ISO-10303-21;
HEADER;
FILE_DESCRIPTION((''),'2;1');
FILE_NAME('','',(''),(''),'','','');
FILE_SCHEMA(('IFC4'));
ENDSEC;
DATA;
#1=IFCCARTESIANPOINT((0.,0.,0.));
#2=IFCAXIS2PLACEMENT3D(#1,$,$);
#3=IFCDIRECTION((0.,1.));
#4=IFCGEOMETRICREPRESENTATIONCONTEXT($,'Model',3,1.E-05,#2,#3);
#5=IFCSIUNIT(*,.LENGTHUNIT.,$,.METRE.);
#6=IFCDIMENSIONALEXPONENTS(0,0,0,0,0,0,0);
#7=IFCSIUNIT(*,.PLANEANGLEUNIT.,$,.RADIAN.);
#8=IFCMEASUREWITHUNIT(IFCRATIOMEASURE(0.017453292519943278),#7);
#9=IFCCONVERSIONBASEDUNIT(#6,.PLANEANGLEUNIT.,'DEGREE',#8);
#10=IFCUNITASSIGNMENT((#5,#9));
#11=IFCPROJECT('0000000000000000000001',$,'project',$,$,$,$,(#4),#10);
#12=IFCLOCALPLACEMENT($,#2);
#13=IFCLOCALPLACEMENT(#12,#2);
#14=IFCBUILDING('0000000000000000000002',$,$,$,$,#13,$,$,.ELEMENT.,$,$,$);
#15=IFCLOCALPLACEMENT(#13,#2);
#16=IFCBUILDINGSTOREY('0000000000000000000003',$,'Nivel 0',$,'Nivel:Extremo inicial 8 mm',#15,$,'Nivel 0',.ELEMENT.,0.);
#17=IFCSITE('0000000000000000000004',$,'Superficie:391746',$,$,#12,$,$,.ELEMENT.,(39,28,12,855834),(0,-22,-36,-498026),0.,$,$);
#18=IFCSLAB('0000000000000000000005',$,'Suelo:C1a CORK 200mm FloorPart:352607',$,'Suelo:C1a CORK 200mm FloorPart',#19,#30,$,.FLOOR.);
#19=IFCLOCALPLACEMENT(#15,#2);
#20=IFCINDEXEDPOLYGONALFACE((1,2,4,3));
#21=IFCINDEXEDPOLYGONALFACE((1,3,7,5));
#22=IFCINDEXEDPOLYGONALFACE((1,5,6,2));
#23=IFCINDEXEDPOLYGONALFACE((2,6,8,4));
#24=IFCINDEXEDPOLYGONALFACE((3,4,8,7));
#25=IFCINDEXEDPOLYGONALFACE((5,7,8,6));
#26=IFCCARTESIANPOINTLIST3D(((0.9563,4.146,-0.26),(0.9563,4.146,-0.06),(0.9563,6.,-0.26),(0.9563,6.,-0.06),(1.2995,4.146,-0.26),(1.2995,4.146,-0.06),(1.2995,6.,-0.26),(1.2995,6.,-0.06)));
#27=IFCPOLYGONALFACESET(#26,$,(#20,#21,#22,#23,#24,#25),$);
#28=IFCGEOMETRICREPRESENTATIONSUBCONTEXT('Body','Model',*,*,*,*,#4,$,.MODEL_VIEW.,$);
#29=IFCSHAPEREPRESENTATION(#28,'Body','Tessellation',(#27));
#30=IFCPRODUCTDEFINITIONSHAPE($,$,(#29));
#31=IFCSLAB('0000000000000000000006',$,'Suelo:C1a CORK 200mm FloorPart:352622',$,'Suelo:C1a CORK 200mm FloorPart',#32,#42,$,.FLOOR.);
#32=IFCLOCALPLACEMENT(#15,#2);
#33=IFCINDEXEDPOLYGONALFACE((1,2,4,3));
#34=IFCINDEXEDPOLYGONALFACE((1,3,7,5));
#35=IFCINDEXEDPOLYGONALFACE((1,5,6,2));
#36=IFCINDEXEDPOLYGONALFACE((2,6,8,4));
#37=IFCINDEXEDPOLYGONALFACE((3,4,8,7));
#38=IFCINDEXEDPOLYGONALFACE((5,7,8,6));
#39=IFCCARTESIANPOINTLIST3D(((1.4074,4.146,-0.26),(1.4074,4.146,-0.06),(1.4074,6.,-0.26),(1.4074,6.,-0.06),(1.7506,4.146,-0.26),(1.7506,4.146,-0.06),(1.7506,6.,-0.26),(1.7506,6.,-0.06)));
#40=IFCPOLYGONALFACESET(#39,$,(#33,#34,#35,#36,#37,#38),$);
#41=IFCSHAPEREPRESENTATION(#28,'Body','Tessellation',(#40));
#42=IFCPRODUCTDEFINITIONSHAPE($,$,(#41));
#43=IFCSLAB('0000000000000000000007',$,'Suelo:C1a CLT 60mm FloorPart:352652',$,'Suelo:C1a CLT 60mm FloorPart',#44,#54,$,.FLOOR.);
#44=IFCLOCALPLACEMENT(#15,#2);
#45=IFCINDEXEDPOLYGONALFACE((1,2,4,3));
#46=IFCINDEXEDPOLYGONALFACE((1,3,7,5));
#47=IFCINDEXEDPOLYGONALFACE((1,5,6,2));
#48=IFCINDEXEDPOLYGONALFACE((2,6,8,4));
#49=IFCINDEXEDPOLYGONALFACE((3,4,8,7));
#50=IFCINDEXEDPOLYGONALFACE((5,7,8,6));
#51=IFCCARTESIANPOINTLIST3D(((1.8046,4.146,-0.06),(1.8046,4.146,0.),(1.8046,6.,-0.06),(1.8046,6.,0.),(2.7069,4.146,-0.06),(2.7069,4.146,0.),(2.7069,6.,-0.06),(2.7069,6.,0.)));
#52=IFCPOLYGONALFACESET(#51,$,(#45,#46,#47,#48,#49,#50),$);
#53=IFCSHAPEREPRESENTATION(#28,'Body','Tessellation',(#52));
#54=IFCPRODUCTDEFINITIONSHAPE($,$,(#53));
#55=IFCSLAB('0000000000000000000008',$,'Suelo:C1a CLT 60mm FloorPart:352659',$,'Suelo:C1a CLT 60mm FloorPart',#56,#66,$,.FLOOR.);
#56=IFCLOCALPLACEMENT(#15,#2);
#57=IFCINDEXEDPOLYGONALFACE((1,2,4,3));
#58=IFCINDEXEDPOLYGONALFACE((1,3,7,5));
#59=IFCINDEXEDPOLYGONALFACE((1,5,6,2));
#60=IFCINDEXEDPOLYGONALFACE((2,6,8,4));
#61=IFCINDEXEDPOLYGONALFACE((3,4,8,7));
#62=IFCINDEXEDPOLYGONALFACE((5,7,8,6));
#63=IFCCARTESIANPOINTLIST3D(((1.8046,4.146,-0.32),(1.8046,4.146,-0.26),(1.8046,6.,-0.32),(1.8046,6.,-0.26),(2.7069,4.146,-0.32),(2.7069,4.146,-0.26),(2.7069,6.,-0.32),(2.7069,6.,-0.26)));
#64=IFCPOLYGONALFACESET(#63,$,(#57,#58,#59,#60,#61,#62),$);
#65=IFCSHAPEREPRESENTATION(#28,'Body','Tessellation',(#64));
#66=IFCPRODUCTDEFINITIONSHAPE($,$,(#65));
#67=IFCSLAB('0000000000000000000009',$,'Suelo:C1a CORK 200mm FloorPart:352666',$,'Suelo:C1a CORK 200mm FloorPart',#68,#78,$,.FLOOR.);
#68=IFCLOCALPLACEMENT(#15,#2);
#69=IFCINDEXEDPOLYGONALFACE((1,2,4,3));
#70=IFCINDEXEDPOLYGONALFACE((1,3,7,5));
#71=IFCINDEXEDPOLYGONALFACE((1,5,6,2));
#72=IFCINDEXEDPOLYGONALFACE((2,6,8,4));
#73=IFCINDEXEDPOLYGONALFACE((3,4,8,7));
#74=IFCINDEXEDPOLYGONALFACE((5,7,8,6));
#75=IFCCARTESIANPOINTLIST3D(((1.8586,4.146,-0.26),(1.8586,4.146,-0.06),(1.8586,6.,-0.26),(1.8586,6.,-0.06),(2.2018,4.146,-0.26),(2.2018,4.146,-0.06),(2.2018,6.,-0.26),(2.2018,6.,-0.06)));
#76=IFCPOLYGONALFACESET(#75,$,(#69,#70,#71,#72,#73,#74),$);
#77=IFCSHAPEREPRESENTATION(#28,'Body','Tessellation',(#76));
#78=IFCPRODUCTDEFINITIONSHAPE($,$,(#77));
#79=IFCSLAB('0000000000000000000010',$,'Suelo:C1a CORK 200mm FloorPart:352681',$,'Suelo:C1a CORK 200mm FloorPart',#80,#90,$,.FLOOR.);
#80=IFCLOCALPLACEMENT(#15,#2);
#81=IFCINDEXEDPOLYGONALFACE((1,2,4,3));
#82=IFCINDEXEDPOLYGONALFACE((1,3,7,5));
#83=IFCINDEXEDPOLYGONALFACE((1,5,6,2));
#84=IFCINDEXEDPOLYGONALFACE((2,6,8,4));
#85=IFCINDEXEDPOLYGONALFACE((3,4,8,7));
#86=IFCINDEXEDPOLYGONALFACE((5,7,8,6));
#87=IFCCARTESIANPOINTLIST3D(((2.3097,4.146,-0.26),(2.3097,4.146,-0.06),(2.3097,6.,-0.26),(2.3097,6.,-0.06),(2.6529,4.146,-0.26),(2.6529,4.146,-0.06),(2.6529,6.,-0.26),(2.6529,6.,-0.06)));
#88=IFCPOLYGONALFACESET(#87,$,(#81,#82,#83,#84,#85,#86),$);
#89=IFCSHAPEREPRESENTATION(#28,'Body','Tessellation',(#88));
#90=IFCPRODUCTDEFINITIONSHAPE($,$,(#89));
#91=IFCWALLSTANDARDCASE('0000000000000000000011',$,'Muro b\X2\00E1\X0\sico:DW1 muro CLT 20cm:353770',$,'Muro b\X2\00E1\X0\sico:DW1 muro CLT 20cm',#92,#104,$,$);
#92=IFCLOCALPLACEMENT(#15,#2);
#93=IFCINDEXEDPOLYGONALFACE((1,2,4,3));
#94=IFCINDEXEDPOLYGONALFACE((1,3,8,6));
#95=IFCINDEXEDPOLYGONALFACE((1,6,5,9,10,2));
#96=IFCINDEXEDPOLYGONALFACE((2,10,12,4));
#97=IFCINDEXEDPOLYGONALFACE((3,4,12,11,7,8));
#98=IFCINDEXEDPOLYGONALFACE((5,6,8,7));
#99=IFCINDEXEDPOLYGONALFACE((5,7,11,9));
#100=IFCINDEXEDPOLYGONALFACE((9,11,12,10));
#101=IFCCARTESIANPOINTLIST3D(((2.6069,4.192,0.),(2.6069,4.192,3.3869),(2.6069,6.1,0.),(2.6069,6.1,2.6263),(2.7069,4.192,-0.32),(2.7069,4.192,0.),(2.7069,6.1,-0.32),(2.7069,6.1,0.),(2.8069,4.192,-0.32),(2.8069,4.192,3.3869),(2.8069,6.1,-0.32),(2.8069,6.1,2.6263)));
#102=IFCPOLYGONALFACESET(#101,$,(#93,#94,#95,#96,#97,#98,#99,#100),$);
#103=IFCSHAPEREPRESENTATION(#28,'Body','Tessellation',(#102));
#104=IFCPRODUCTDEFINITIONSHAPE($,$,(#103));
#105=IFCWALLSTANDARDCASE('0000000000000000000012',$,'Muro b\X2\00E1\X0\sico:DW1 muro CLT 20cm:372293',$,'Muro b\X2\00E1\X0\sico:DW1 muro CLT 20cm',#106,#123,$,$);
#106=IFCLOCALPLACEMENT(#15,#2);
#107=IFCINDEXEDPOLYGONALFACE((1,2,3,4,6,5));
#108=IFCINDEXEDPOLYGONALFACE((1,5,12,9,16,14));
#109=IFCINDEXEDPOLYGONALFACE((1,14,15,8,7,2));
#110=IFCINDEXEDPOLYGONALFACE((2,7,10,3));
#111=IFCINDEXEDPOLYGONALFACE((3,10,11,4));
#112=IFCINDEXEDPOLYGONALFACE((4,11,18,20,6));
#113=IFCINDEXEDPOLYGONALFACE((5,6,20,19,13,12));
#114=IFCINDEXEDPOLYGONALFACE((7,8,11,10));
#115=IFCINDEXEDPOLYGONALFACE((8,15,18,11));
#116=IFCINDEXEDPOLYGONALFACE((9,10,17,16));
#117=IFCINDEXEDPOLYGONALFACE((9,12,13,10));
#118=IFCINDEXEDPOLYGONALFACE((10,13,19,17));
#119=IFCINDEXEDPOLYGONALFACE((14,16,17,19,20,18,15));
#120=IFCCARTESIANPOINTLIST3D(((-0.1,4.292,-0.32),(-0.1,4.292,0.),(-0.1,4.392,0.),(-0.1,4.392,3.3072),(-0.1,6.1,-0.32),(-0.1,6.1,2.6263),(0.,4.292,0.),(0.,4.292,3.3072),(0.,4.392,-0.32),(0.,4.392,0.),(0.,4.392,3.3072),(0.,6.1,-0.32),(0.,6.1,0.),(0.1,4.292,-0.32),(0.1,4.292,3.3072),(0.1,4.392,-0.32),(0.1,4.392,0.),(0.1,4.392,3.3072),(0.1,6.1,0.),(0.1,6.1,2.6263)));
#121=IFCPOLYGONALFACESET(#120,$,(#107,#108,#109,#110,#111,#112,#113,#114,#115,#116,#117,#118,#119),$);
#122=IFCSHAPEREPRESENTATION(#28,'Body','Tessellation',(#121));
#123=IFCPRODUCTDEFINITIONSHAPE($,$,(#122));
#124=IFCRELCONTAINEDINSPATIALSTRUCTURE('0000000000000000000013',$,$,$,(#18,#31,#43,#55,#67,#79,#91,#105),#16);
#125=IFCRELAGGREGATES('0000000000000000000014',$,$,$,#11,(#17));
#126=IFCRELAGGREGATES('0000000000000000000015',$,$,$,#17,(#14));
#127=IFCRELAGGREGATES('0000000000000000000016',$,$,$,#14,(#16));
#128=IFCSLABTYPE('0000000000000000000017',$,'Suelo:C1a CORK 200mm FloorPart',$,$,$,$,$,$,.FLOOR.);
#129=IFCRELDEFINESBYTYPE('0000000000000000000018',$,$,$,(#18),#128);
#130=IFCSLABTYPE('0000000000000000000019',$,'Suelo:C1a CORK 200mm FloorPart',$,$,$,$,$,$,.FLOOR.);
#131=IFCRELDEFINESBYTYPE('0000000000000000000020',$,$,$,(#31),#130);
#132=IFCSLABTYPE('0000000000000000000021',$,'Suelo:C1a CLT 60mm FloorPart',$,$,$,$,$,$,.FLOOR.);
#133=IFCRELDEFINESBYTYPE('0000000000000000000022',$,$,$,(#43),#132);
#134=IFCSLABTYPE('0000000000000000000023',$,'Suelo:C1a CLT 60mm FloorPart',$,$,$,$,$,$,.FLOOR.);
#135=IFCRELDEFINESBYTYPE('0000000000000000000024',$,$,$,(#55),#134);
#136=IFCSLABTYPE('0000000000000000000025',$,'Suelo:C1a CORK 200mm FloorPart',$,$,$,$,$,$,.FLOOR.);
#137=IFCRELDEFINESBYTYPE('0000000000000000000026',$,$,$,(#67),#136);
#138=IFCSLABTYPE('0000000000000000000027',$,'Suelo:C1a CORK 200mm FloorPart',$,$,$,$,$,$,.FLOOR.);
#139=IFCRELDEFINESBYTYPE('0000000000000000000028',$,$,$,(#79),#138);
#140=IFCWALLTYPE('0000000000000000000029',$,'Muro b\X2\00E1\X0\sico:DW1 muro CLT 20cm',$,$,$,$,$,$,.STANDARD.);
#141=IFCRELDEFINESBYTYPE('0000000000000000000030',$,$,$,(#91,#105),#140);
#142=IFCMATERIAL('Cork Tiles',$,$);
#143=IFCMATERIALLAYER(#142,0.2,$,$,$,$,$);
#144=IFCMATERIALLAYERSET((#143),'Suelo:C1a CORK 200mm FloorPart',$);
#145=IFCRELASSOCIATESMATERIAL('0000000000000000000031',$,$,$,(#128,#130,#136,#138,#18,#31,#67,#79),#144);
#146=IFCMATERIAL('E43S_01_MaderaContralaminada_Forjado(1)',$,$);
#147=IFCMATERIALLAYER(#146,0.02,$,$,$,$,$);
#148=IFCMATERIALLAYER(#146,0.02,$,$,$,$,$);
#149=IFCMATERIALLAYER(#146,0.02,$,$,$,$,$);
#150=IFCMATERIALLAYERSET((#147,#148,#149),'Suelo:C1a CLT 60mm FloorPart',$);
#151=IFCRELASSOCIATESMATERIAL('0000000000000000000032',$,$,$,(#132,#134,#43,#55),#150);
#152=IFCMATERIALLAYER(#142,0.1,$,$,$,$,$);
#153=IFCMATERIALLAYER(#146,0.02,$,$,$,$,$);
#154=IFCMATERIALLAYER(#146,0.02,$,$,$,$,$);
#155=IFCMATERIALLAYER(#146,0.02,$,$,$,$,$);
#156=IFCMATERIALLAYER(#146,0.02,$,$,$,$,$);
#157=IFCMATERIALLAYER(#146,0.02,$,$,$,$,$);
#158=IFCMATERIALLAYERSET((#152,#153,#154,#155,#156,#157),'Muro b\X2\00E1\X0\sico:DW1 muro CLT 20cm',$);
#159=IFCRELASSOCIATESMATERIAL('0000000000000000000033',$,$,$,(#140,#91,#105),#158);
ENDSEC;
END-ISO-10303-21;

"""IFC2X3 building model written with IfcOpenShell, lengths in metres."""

from ifc_helpers import new_model, entity, si_unit, converted_unit, direction, frame, frame_2d, origin, origin_2d_with_axis, place, context, subcontext, project, spatial, polyline, rectangle, extrude, clip, bounded_halfspace, material, layer, layer_set, layer_usage, type_object, element, save


model = new_model("IFC2X3")

# Units and contexts
model_context = context("Model", 3, precision=1e-05, world=origin(), true_north=direction((0.0, 1.0)))
body_context = subcontext(model_context, "Body", "Model", "MODEL_VIEW")
ifc_project = project(units=[si_unit("LENGTHUNIT", "METRE"), converted_unit("PLANEANGLEUNIT", "DEGREE", entity("IfcRatioMeasure", 0.017453292519943278), si_unit("PLANEANGLEUNIT", "RADIAN"), dimensions=[0, 0, 0, 0, 0, 0, 0])], contexts=[model_context])

# Site, building, storey
site_placement = place(None, origin())
site = spatial("IfcSite", under=ifc_project, at=site_placement, Name="Superficie:391746", CompositionType="ELEMENT", RefLatitude=(39, 28, 12, 855834), RefLongitude=(0, -22, -36, -498026), RefElevation=0.0)
building_placement = place(site_placement, origin())
building = spatial("IfcBuilding", under=site, at=building_placement, CompositionType="ELEMENT")
storey_placement = place(building_placement, origin())
storey = spatial("IfcBuildingStorey", under=building, at=storey_placement, Name="Nivel 0", ObjectType="Nivel:Extremo inicial 8 mm", LongName="Nivel 0", CompositionType="ELEMENT", Elevation=0.0)

# Shared definitions
ifc_material_1 = material(Name="E43S_01_MaderaContralaminada_Forjado(1)")

# Slabs
ifc_layer_1 = layer(ifc_material_1, 0.02)
ifc_layer_2 = layer(ifc_material_1, 0.02)
ifc_layer_3 = layer(ifc_material_1, 0.02)
ifc_layer_set_1 = layer_set([ifc_layer_1, ifc_layer_2, ifc_layer_3], Name="Suelo:C1a CLT 60mm FloorPart")
ifc_material_2 = material(Name="Cork Tiles")
ifc_layer_4 = layer(ifc_material_2, 0.2)
ifc_layer_set_2 = layer_set([ifc_layer_4], Name="Suelo:C1a CORK 200mm FloorPart")
ifc_layer_usage_1 = layer_usage(ifc_layer_set_2, "AXIS3", "POSITIVE", 0.0)
slab_type_1 = type_object("IfcSlabType", Name="Suelo:C1a CORK 200mm FloorPart", PredefinedType="FLOOR", material=ifc_layer_set_2)
slab_1_placement = place(storey_placement, origin())
element("IfcSlab", 1, at=slab_1_placement, inside=storey, type_object=slab_type_1, material=ifc_layer_usage_1, Name="Suelo:C1a CORK 200mm FloorPart:352607", ObjectType="Suelo:C1a CORK 200mm FloorPart", PredefinedType="FLOOR", context=body_context, shape_type="SweptSolid", body=[
    extrude(rectangle(XDim=1.854, YDim=0.3432, at=frame_2d((0.0, 0.0), x_axis=(1.0, 0.0))), frame((1.1279, 5.073, -0.06), z_axis=(0.0, 0.0, -1.0), x_axis=(0.0, 1.0, 0.0)), (0.0, 0.0, 1.0), 0.2),
])
ifc_layer_usage_2 = layer_usage(ifc_layer_set_2, "AXIS3", "POSITIVE", 0.0)
slab_type_2 = type_object("IfcSlabType", Name="Suelo:C1a CORK 200mm FloorPart", PredefinedType="FLOOR", material=ifc_layer_set_2)
slab_2_placement = place(storey_placement, origin())
element("IfcSlab", 2, at=slab_2_placement, inside=storey, type_object=slab_type_2, material=ifc_layer_usage_2, Name="Suelo:C1a CORK 200mm FloorPart:352622", ObjectType="Suelo:C1a CORK 200mm FloorPart", PredefinedType="FLOOR", context=body_context, shape_type="SweptSolid", body=[
    extrude(rectangle(XDim=1.854, YDim=0.3432, at=frame_2d((0.0, 0.0), x_axis=(1.0, 0.0))), frame((1.579, 5.073, -0.06), z_axis=(0.0, 0.0, -1.0), x_axis=(0.0, 1.0, 0.0)), (0.0, 0.0, 1.0), 0.2),
])
ifc_layer_usage_3 = layer_usage(ifc_layer_set_1, "AXIS3", "POSITIVE", 0.0)
slab_type_3 = type_object("IfcSlabType", Name="Suelo:C1a CLT 60mm FloorPart", PredefinedType="FLOOR", material=ifc_layer_set_1)
slab_3_placement = place(storey_placement, origin())
element("IfcSlab", 3, at=slab_3_placement, inside=storey, type_object=slab_type_3, material=ifc_layer_usage_3, Name="Suelo:C1a CLT 60mm FloorPart:352652", ObjectType="Suelo:C1a CLT 60mm FloorPart", PredefinedType="FLOOR", context=body_context, shape_type="SweptSolid", body=[
    extrude(rectangle(XDim=1.854, YDim=0.9023, at=frame_2d((0.0, 0.0), x_axis=(1.0, 0.0))), frame((2.2558, 5.073, 0.0), z_axis=(0.0, 0.0, -1.0), x_axis=(0.0, 1.0, 0.0)), (0.0, 0.0, 1.0), 0.06),
])
ifc_layer_usage_4 = layer_usage(ifc_layer_set_1, "AXIS3", "POSITIVE", 0.0)
slab_type_4 = type_object("IfcSlabType", Name="Suelo:C1a CLT 60mm FloorPart", PredefinedType="FLOOR", material=ifc_layer_set_1)
slab_4_placement = place(storey_placement, origin())
element("IfcSlab", 4, at=slab_4_placement, inside=storey, type_object=slab_type_4, material=ifc_layer_usage_4, Name="Suelo:C1a CLT 60mm FloorPart:352659", ObjectType="Suelo:C1a CLT 60mm FloorPart", PredefinedType="FLOOR", context=body_context, shape_type="SweptSolid", body=[
    extrude(rectangle(XDim=1.854, YDim=0.9023, at=frame_2d((0.0, 0.0), x_axis=(1.0, 0.0))), frame((2.2558, 5.073, -0.26), z_axis=(0.0, 0.0, -1.0), x_axis=(0.0, 1.0, 0.0)), (0.0, 0.0, 1.0), 0.06),
])
ifc_layer_usage_5 = layer_usage(ifc_layer_set_2, "AXIS3", "POSITIVE", 0.0)
slab_type_5 = type_object("IfcSlabType", Name="Suelo:C1a CORK 200mm FloorPart", PredefinedType="FLOOR", material=ifc_layer_set_2)
slab_5_placement = place(storey_placement, origin())
element("IfcSlab", 5, at=slab_5_placement, inside=storey, type_object=slab_type_5, material=ifc_layer_usage_5, Name="Suelo:C1a CORK 200mm FloorPart:352666", ObjectType="Suelo:C1a CORK 200mm FloorPart", PredefinedType="FLOOR", context=body_context, shape_type="SweptSolid", body=[
    extrude(rectangle(XDim=1.854, YDim=0.3432, at=frame_2d((0.0, 0.0), x_axis=(1.0, 0.0))), frame((2.0302, 5.073, -0.06), z_axis=(0.0, 0.0, -1.0), x_axis=(0.0, 1.0, 0.0)), (0.0, 0.0, 1.0), 0.2),
])
ifc_layer_usage_6 = layer_usage(ifc_layer_set_2, "AXIS3", "POSITIVE", 0.0)
slab_type_6 = type_object("IfcSlabType", Name="Suelo:C1a CORK 200mm FloorPart", PredefinedType="FLOOR", material=ifc_layer_set_2)
slab_6_placement = place(storey_placement, origin())
element("IfcSlab", 6, at=slab_6_placement, inside=storey, type_object=slab_type_6, material=ifc_layer_usage_6, Name="Suelo:C1a CORK 200mm FloorPart:352681", ObjectType="Suelo:C1a CORK 200mm FloorPart", PredefinedType="FLOOR", context=body_context, shape_type="SweptSolid", body=[
    extrude(rectangle(XDim=1.854, YDim=0.3432, at=origin_2d_with_axis()), frame((2.4813, 5.073, -0.06), z_axis=(0.0, 0.0, -1.0), x_axis=(0.0, 1.0, 0.0)), (0.0, 0.0, 1.0), 0.2),
])

# Walls
ifc_layer_5 = layer(ifc_material_2, 0.1)
ifc_layer_6 = layer(ifc_material_1, 0.02)
ifc_layer_7 = layer(ifc_material_1, 0.02)
ifc_layer_8 = layer(ifc_material_1, 0.02)
ifc_layer_9 = layer(ifc_material_1, 0.02)
ifc_layer_10 = layer(ifc_material_1, 0.02)
ifc_layer_set_3 = layer_set([ifc_layer_5, ifc_layer_6, ifc_layer_7, ifc_layer_8, ifc_layer_9, ifc_layer_10], Name="Muro básico:DW1 muro CLT 20cm")
ifc_layer_usage_7 = layer_usage(ifc_layer_set_3, "AXIS2", "NEGATIVE", 0.1)
wall_type_1 = type_object("IfcWallType", Name="Muro básico:DW1 muro CLT 20cm", PredefinedType="STANDARD", material=ifc_layer_set_3)
wall_1_placement = place(storey_placement, frame((2.7069, 6.1, -0.32), z_axis=(0.0, 0.0, 1.0), x_axis=(0.0, -1.0, 0.0)))
element("IfcWallStandardCase", 7, at=wall_1_placement, inside=storey, type_object=wall_type_1, material=ifc_layer_usage_7, Name="Muro básico:DW1 muro CLT 20cm:353770", ObjectType="Muro básico:DW1 muro CLT 20cm", context=body_context, shape_type="Clipping", body=[
    clip(clip(extrude(rectangle(XDim=1.908, YDim=0.2, at=frame_2d((0.954, 0.0), x_axis=(-1.0, 0.0))), origin(), (0.0, 0.0, 1.0), 3.7069), bounded_halfspace(frame((0.0, -0.1, 2.9463), z_axis=(-0.370288, 0.0, 0.928917), x_axis=(0.0, -1.0, 0.0)), False, frame((0.0, -0.1, 2.9463)), polyline([(0.0, 0.0), (0.2, 0.0), (1.708, 0.0), (1.908, 0.0), (1.908, 0.2), (0.0, 0.2), (0.0, 0.0)]))), bounded_halfspace(frame((1.908, -0.1, 0.32), z_axis=(0.0, 0.0, -1.0), x_axis=(0.0, 1.0, 0.0)), False, frame((1.908, -0.1, 0.32)), polyline([(0.0, 0.0), (0.0, 0.1), (-0.1, 0.1), (-1.808, 0.1), (-1.908, 0.1), (-1.908, 0.0), (-1.708, 0.0), (-0.2, 0.0), (0.0, 0.0)]))),
])
ifc_layer_usage_8 = layer_usage(ifc_layer_set_3, "AXIS2", "NEGATIVE", 0.1)
wall_2_placement = place(storey_placement, frame((0.0, 4.292, -0.32), z_axis=(0.0, 0.0, 1.0), x_axis=(0.0, 1.0, 0.0)))
element("IfcWallStandardCase", 8, at=wall_2_placement, inside=storey, type_object=wall_type_1, material=ifc_layer_usage_8, Name="Muro básico:DW1 muro CLT 20cm:372293", ObjectType="Muro básico:DW1 muro CLT 20cm", context=body_context, shape_type="Clipping", body=[
    clip(clip(clip(extrude(rectangle(XDim=1.808, YDim=0.2, at=frame_2d((0.904, 0.0), x_axis=(-1.0, 0.0))), origin(), (0.0, 0.0, 1.0), 3.6272), bounded_halfspace(frame((0.1, -0.1, 3.6272), z_axis=(0.370288, 0.0, 0.928917), x_axis=(0.0, 1.0, 0.0)), False, frame((0.1, -0.1, 3.6272)), polyline([(0.0, 0.0), (1.508, 0.0), (1.708, 0.0), (1.708, 0.2), (0.0, 0.2), (0.0, 0.0)]))), bounded_halfspace(frame((1.808, -0.1, 0.32), z_axis=(0.0, 0.0, -1.0), x_axis=(0.0, 1.0, 0.0)), False, frame((1.808, -0.1, 0.32)), polyline([(0.0, 0.0), (0.0, 0.1), (-1.708, 0.1), (-1.708, 0.0), (-0.2, 0.0), (-0.1, 0.0), (0.0, 0.0)]))), bounded_halfspace(frame((0.0, 0.0, 0.32)), False, frame((0.0, 0.0, 0.32)), polyline([(0.0, 0.0), (0.1, 0.0), (0.1, 0.1), (0.0, 0.1), (0.0, 0.0)]))),
])

save(model, "model.ifc")
